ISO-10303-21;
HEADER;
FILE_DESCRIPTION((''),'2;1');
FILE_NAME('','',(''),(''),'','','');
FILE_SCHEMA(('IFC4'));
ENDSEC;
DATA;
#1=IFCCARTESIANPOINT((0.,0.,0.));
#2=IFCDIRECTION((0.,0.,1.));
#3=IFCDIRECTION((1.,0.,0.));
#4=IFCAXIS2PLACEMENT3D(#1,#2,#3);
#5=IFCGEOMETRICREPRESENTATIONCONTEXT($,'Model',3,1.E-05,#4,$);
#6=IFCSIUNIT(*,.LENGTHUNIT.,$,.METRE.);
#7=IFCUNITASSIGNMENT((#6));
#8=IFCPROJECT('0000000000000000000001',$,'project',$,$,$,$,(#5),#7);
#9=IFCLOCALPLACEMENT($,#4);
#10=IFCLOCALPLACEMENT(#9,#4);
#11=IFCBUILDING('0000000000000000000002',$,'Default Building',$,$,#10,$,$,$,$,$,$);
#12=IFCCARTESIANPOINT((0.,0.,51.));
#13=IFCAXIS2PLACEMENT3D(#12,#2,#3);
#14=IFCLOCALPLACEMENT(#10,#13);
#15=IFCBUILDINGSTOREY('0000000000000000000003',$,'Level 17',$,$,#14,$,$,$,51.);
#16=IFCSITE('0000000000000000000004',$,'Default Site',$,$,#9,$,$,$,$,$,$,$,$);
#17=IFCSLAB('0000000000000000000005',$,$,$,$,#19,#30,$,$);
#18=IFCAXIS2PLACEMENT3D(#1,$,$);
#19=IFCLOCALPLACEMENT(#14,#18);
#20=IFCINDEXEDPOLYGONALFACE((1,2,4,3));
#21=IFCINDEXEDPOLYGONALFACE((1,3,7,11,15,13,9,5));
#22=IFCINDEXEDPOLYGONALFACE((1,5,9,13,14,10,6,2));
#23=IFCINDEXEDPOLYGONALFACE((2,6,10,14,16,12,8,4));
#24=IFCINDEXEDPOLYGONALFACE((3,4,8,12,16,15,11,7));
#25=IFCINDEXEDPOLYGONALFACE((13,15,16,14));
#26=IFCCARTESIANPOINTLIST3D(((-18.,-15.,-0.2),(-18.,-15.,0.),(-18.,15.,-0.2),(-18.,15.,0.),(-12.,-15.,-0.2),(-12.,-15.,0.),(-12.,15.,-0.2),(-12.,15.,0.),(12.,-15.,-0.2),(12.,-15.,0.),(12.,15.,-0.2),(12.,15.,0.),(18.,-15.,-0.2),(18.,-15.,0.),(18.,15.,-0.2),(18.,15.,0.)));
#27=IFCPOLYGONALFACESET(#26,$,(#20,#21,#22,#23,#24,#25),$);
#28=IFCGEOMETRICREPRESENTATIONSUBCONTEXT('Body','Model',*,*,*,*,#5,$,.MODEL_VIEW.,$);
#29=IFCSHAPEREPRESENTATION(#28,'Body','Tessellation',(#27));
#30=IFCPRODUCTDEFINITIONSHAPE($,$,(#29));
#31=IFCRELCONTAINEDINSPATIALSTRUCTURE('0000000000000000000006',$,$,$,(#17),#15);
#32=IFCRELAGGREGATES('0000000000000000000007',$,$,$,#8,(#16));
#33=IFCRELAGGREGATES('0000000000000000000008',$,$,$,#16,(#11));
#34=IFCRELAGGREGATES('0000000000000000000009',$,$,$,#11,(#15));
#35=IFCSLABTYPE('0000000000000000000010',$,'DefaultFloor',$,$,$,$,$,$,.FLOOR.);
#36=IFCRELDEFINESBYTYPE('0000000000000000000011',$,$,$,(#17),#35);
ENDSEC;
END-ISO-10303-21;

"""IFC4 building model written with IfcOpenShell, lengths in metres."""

from ifc_helpers import new_model, si_unit, frame, origin_with_axes, place, context, subcontext, project, spatial, polyline, outline, extrude, type_object, element, save


model = new_model("IFC4")

# Units and contexts
model_context = context("Model", 3, precision=1e-05, world=origin_with_axes())
body_context = subcontext(model_context, "Body", "Model", "MODEL_VIEW")
ifc_project = project(units=[si_unit("LENGTHUNIT", "METRE")], contexts=[model_context])

# Site, building, storey
site_placement = place(None, origin_with_axes())
site = spatial("IfcSite", under=ifc_project, at=site_placement, Name="Default Site")
building_placement = place(site_placement, origin_with_axes())
building = spatial("IfcBuilding", under=site, at=building_placement, Name="Default Building")
storey_placement = place(building_placement, frame((0.0, 0.0, 51.0), z_axis=(0.0, 0.0, 1.0), x_axis=(1.0, 0.0, 0.0)))
storey = spatial("IfcBuildingStorey", under=building, at=storey_placement, Name="Level 17", Elevation=51.0)

# Slab
slab_type = type_object("IfcSlabType", Name="DefaultFloor", PredefinedType="FLOOR")
slab_placement = place(storey_placement, frame((0.0, 0.0, -51.0), z_axis=(0.0, 0.0, 1.0), x_axis=(1.0, 0.0, 0.0)))
element("IfcSlab", 1, at=slab_placement, inside=storey, type_object=slab_type, context=body_context, shape_type="SweptSolid", body=[
    extrude(outline(polyline([(-18.0, -15.0), (-18.0, 15.0), (-12.0, 15.0), (12.0, 15.0), (18.0, 15.0), (18.0, -15.0), (12.0, -15.0), (-12.0, -15.0), (-18.0, -15.0)])), frame((0.0, 0.0, 51.0), z_axis=(0.0, 0.0, 1.0), x_axis=(1.0, 0.0, 0.0)), (0.0, 0.0, -1.0), 0.2),
])

save(model, "model.ifc")
